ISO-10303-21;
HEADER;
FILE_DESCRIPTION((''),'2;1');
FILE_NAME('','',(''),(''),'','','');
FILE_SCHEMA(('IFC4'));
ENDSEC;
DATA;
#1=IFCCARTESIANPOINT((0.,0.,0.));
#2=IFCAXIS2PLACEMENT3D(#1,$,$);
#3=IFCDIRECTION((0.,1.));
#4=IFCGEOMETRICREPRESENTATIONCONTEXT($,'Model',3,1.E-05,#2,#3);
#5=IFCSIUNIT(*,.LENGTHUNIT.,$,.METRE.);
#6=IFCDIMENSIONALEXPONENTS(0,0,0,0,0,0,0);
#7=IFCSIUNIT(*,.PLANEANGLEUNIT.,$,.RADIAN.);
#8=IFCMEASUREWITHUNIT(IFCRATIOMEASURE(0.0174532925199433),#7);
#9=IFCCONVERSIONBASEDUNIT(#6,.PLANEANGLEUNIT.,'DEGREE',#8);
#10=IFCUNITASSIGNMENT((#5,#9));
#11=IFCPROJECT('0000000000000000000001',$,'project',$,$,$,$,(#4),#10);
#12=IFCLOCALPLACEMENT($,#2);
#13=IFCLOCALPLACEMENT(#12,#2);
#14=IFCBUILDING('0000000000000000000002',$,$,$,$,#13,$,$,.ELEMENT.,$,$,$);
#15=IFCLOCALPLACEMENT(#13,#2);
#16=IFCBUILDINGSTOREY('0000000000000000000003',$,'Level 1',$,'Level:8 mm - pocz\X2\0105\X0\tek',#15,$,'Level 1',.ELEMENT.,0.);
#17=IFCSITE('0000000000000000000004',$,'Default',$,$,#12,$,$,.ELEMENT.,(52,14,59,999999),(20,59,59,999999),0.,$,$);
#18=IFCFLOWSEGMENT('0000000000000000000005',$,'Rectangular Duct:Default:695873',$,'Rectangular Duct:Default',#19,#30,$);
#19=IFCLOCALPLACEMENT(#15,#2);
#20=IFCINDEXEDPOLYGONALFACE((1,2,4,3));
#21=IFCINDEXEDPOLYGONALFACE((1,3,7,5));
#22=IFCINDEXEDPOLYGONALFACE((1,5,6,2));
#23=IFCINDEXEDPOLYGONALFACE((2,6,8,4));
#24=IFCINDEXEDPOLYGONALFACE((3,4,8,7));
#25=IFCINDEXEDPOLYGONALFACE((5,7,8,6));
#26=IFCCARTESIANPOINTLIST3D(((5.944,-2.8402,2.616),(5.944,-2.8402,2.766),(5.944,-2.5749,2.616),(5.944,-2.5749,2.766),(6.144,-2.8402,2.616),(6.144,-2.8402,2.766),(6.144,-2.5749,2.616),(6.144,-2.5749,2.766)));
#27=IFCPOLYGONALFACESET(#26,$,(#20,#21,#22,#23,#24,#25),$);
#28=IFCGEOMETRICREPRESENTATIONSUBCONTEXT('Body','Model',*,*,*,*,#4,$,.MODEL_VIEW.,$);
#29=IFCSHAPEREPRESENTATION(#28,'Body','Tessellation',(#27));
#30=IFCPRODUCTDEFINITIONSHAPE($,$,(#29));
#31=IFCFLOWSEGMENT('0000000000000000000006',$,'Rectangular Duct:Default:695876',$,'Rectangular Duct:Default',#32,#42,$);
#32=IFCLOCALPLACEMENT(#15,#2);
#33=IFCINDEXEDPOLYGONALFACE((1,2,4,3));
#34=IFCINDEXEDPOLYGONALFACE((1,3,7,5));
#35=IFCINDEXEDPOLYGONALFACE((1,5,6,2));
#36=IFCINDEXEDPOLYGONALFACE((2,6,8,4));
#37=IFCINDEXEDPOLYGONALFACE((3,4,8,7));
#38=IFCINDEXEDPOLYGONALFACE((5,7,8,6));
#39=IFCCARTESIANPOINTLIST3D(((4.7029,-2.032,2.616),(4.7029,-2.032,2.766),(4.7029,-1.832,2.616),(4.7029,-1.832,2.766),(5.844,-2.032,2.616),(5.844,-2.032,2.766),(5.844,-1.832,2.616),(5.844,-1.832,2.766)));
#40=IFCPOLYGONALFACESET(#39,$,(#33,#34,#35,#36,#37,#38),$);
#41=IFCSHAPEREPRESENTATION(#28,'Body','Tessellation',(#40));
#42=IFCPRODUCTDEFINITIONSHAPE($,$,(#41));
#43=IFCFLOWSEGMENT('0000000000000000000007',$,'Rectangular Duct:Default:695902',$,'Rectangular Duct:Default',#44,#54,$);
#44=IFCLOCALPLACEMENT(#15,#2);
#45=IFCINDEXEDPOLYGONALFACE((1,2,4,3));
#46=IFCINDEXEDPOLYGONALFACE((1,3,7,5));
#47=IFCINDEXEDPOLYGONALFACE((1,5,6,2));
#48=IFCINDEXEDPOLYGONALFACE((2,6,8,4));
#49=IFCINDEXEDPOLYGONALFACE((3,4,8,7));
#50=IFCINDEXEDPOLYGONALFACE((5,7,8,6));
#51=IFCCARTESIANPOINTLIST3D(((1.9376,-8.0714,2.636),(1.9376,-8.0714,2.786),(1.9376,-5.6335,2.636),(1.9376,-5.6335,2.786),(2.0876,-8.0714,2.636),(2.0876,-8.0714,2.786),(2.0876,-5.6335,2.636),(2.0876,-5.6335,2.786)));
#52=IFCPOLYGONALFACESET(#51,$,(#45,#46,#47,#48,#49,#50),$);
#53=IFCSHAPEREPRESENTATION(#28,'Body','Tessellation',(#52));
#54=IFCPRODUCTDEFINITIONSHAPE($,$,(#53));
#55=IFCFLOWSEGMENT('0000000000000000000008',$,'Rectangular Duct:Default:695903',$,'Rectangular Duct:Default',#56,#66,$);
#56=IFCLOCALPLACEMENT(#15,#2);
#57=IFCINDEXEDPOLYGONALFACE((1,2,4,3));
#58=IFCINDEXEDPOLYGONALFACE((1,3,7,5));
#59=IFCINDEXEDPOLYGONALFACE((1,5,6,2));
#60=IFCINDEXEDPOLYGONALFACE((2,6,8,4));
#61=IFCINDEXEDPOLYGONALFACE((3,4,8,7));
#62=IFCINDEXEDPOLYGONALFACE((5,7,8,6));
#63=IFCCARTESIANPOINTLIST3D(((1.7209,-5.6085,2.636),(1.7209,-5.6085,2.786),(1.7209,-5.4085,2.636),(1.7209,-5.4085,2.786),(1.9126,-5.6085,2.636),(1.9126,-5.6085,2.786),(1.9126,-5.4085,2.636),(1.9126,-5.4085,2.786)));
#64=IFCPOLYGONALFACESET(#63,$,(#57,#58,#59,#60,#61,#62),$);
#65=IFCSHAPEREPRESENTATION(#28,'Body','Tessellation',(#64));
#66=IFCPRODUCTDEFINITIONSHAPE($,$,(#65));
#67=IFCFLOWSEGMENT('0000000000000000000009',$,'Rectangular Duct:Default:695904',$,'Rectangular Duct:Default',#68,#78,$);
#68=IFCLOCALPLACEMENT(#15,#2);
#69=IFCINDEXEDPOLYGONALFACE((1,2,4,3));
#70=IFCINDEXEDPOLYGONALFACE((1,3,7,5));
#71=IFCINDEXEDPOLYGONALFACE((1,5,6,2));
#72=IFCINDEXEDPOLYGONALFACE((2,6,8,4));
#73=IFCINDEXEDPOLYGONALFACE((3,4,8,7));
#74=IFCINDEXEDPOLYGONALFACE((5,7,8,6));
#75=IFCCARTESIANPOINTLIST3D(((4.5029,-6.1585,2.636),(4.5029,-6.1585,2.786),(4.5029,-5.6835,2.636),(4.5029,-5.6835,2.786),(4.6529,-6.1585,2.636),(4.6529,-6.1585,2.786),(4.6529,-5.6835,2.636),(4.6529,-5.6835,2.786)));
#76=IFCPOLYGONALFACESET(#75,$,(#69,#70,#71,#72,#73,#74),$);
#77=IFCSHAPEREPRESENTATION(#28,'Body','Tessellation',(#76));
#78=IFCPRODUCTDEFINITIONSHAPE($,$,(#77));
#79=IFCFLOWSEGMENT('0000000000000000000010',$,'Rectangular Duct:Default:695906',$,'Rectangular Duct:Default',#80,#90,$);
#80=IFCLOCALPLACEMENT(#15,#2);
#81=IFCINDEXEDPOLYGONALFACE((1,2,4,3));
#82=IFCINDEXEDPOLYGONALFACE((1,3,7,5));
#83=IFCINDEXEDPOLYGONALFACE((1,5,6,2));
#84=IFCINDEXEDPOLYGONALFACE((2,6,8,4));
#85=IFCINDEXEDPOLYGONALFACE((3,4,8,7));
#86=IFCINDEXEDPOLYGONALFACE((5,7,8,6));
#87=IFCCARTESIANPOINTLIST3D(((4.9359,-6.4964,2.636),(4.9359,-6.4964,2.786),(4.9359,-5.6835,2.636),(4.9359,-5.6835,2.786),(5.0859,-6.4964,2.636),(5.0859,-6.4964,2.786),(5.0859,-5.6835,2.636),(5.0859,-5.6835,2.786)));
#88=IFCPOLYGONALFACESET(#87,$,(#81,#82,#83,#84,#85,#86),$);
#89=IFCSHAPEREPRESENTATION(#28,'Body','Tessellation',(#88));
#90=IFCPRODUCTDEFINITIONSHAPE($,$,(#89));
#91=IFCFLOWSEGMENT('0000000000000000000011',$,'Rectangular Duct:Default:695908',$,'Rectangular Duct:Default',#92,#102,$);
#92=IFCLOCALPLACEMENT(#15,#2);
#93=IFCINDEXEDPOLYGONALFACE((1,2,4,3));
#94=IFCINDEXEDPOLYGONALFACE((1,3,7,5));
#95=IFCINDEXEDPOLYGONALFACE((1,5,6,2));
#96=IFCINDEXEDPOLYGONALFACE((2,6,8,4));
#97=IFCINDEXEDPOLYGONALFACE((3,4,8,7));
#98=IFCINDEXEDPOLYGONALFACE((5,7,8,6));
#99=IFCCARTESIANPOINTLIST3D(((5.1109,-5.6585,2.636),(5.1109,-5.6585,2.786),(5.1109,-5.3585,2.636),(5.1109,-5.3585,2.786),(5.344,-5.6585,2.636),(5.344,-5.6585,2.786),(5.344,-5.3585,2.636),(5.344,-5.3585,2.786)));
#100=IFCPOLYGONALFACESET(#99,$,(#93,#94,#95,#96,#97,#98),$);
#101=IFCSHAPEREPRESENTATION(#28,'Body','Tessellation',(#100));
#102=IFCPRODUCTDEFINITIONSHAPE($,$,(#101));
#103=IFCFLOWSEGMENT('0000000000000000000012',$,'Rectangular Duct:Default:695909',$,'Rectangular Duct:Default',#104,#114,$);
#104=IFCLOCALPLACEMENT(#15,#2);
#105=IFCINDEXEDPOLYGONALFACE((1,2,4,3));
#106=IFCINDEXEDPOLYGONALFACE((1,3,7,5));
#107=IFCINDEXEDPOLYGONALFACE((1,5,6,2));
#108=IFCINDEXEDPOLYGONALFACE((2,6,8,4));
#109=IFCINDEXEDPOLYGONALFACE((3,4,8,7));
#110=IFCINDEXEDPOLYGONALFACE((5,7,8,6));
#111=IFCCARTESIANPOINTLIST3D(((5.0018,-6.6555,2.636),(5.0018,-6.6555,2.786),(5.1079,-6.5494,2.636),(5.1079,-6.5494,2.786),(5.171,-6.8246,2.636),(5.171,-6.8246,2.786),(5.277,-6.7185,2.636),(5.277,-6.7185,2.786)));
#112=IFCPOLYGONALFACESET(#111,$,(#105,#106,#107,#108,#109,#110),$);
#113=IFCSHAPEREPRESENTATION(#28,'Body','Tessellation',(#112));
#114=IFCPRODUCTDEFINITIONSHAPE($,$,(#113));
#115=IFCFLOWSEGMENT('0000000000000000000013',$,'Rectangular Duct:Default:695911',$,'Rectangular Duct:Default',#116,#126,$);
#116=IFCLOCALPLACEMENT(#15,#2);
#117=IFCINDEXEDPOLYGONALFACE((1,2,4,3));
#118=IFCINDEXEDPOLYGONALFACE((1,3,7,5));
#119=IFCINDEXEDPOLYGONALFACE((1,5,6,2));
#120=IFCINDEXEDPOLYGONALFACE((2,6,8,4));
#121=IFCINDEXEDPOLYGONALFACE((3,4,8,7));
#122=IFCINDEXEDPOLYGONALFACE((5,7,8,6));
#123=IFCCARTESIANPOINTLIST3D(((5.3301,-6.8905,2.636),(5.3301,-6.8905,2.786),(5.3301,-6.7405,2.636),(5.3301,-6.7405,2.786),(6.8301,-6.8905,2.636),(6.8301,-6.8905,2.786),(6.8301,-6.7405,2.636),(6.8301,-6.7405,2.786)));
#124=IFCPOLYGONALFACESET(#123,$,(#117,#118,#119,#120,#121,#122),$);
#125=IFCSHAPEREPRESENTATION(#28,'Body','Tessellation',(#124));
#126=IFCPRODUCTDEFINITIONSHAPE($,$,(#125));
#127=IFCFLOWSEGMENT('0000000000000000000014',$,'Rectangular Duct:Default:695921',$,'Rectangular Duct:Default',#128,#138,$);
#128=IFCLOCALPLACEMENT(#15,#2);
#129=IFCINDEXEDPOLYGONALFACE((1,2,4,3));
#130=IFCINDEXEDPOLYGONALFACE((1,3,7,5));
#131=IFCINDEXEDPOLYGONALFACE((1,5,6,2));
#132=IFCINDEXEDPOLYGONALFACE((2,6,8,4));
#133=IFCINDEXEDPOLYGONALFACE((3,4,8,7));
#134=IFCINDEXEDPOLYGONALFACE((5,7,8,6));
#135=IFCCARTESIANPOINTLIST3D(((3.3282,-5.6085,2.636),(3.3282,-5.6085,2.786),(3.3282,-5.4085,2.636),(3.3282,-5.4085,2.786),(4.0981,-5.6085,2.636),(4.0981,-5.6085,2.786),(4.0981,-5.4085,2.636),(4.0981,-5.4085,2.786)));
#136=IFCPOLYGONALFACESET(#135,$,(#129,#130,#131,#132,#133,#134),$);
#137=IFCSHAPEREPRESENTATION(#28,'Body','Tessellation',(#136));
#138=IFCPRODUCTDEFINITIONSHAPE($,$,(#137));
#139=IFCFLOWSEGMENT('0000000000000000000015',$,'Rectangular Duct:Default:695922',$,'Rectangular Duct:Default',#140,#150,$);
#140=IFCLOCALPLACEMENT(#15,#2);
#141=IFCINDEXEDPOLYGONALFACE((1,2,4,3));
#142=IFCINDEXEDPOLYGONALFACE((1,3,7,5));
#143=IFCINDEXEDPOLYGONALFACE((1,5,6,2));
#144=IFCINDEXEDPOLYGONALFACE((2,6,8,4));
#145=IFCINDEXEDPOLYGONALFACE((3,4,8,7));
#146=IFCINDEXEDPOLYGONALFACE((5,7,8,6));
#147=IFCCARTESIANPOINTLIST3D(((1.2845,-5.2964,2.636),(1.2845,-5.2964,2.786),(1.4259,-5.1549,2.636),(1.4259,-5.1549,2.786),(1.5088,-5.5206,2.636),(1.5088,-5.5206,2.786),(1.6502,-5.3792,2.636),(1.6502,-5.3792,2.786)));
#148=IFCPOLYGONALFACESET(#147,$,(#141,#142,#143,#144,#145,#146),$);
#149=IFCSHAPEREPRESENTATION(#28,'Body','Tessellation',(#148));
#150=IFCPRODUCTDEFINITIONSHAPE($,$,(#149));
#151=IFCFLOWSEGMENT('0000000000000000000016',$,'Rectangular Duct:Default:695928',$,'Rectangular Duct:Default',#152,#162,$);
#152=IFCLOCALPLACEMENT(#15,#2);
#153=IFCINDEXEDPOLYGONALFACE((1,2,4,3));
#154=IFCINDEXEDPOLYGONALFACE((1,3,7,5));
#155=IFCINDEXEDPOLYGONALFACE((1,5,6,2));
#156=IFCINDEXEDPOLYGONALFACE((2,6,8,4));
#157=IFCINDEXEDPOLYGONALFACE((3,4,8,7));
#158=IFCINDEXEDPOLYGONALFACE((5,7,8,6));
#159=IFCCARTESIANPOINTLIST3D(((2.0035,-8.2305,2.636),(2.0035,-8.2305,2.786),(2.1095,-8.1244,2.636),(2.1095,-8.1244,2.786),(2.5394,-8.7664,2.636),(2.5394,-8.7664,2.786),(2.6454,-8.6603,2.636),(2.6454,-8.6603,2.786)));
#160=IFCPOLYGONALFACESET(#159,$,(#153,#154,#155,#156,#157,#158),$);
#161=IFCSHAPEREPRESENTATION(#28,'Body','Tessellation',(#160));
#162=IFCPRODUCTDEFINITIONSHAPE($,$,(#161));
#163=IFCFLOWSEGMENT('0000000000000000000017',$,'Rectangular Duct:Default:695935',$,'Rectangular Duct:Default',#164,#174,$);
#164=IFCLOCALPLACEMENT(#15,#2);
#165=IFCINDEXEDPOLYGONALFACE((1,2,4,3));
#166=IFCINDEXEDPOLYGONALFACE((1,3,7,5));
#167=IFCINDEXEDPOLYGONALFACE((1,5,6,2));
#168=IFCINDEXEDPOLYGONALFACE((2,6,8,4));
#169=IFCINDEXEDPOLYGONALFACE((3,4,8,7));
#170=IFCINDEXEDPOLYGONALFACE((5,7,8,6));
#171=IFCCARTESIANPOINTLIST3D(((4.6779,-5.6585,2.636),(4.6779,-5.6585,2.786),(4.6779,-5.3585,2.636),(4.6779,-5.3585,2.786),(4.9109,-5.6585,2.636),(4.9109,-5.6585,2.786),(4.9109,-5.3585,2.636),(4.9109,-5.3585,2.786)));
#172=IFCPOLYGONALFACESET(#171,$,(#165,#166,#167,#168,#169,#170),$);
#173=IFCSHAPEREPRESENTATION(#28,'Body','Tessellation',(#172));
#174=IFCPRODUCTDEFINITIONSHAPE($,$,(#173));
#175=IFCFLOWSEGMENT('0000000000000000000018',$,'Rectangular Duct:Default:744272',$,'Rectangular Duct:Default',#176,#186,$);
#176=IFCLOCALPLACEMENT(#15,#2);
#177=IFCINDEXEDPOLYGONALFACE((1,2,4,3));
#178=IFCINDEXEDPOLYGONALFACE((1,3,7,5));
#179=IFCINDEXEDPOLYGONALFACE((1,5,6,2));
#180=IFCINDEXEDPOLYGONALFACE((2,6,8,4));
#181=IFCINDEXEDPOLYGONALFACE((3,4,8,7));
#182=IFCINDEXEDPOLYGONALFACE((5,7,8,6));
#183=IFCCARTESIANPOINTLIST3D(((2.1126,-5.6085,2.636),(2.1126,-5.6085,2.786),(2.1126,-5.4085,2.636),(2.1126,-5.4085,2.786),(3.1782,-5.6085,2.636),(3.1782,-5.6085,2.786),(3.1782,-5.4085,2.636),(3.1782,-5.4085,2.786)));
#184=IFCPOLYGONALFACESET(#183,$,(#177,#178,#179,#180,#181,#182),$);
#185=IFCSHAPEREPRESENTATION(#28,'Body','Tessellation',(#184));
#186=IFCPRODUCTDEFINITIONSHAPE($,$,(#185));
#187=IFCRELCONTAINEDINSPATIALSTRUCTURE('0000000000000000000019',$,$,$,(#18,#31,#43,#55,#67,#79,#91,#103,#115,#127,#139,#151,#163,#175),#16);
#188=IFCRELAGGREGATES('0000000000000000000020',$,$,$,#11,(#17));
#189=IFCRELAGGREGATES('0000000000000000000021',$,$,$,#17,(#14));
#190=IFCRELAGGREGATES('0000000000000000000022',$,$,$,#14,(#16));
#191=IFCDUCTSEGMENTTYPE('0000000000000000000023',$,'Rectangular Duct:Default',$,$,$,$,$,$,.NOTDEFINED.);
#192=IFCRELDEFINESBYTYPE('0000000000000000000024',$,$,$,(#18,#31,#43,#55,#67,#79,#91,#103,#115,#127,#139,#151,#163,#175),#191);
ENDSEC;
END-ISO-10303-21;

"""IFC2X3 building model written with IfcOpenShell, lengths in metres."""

from ifc_helpers import new_model, entity, si_unit, converted_unit, direction, frame, frame_2d, origin, origin_2d_with_axis, place, context, subcontext, project, spatial, rectangle, extrude, type_object, element, save


model = new_model("IFC2X3")

# Units and contexts
model_context = context("Model", 3, precision=1e-05, world=origin(), true_north=direction((0.0, 1.0)))
body_context = subcontext(model_context, "Body", "Model", "MODEL_VIEW")
ifc_project = project(units=[si_unit("LENGTHUNIT", "METRE"), converted_unit("PLANEANGLEUNIT", "DEGREE", entity("IfcRatioMeasure", 0.0174532925199433), si_unit("PLANEANGLEUNIT", "RADIAN"), dimensions=[0, 0, 0, 0, 0, 0, 0])], contexts=[model_context])

# Site, building, storey
site_placement = place(None, origin())
site = spatial("IfcSite", under=ifc_project, at=site_placement, Name="Default", CompositionType="ELEMENT", RefLatitude=(52, 14, 59, 999999), RefLongitude=(20, 59, 59, 999999), RefElevation=0.0)
building_placement = place(site_placement, origin())
building = spatial("IfcBuilding", under=site, at=building_placement, CompositionType="ELEMENT")
storey_placement = place(building_placement, origin())
storey = spatial("IfcBuildingStorey", under=building, at=storey_placement, Name="Level 1", ObjectType="Level:8 mm - początek", LongName="Level 1", CompositionType="ELEMENT", Elevation=0.0)

# Flow segments
duct_segment_type_1 = type_object("IfcDuctSegmentType", Name="Rectangular Duct:Default", PredefinedType="NOTDEFINED")
flow_segment_1_placement = place(storey_placement, origin())
element("IfcFlowSegment", 1, at=flow_segment_1_placement, inside=storey, type_object=duct_segment_type_1, Name="Rectangular Duct:Default:695873", ObjectType="Rectangular Duct:Default", context=body_context, shape_type="SweptSolid", body=[
    extrude(rectangle(XDim=0.2654, YDim=0.2, at=frame_2d((0.0, 0.0), x_axis=(1.0, 0.0))), frame((6.044, -2.7075, 2.616), z_axis=(0.0, 0.0, 1.0), x_axis=(0.0, 1.0, 0.0)), (0.0, 0.0, 1.0), 0.15),
])
flow_segment_2_placement = place(storey_placement, origin())
element("IfcFlowSegment", 2, at=flow_segment_2_placement, inside=storey, type_object=duct_segment_type_1, Name="Rectangular Duct:Default:695876", ObjectType="Rectangular Duct:Default", context=body_context, shape_type="SweptSolid", body=[
    extrude(rectangle(XDim=1.1411, YDim=0.2, at=frame_2d((0.0, 0.0), x_axis=(1.0, 0.0))), frame((5.2734, -1.932, 2.616), z_axis=(0.0, 0.0, 1.0), x_axis=(-1.0, 0.0, 0.0)), (0.0, 0.0, 1.0), 0.15),
])
flow_segment_3_placement = place(storey_placement, origin())
element("IfcFlowSegment", 3, at=flow_segment_3_placement, inside=storey, type_object=duct_segment_type_1, Name="Rectangular Duct:Default:695902", ObjectType="Rectangular Duct:Default", context=body_context, shape_type="SweptSolid", body=[
    extrude(rectangle(XDim=2.4379, YDim=0.15, at=frame_2d((0.0, 0.0), x_axis=(1.0, 0.0))), frame((2.0126, -6.8524, 2.636), z_axis=(0.0, 0.0, 1.0), x_axis=(0.0, -1.0, 0.0)), (0.0, 0.0, 1.0), 0.15),
])
flow_segment_4_placement = place(storey_placement, origin())
element("IfcFlowSegment", 4, at=flow_segment_4_placement, inside=storey, type_object=duct_segment_type_1, Name="Rectangular Duct:Default:695903", ObjectType="Rectangular Duct:Default", context=body_context, shape_type="SweptSolid", body=[
    extrude(rectangle(XDim=0.1917, YDim=0.2, at=frame_2d((0.0, 0.0), x_axis=(1.0, 0.0))), frame((1.8167, -5.5085, 2.636), z_axis=(0.0, 0.0, 1.0), x_axis=(-1.0, 0.0, 0.0)), (0.0, 0.0, 1.0), 0.15),
])
flow_segment_5_placement = place(storey_placement, origin())
element("IfcFlowSegment", 5, at=flow_segment_5_placement, inside=storey, type_object=duct_segment_type_1, Name="Rectangular Duct:Default:695904", ObjectType="Rectangular Duct:Default", context=body_context, shape_type="SweptSolid", body=[
    extrude(rectangle(XDim=0.475, YDim=0.15, at=frame_2d((0.0, 0.0), x_axis=(1.0, 0.0))), frame((4.5779, -5.921, 2.636), z_axis=(0.0, 0.0, 1.0), x_axis=(0.0, 1.0, 0.0)), (0.0, 0.0, 1.0), 0.15),
])
flow_segment_6_placement = place(storey_placement, origin())
element("IfcFlowSegment", 6, at=flow_segment_6_placement, inside=storey, type_object=duct_segment_type_1, Name="Rectangular Duct:Default:695906", ObjectType="Rectangular Duct:Default", context=body_context, shape_type="SweptSolid", body=[
    extrude(rectangle(XDim=0.8129, YDim=0.15, at=origin_2d_with_axis()), frame((5.0109, -6.0899, 2.636), z_axis=(0.0, 0.0, 1.0), x_axis=(0.0, -1.0, 0.0)), (0.0, 0.0, 1.0), 0.15),
])
flow_segment_7_placement = place(storey_placement, origin())
element("IfcFlowSegment", 7, at=flow_segment_7_placement, inside=storey, type_object=duct_segment_type_1, Name="Rectangular Duct:Default:695908", ObjectType="Rectangular Duct:Default", context=body_context, shape_type="SweptSolid", body=[
    extrude(rectangle(XDim=0.2331, YDim=0.3, at=frame_2d((0.0, 0.0), x_axis=(1.0, 0.0))), frame((5.2275, -5.5085, 2.636), z_axis=(0.0, 0.0, 1.0), x_axis=(-1.0, 0.0, 0.0)), (0.0, 0.0, 1.0), 0.15),
])
flow_segment_8_placement = place(storey_placement, origin())
element("IfcFlowSegment", 8, at=flow_segment_8_placement, inside=storey, type_object=duct_segment_type_1, Name="Rectangular Duct:Default:695909", ObjectType="Rectangular Duct:Default", context=body_context, shape_type="SweptSolid", body=[
    extrude(rectangle(XDim=0.2392, YDim=0.15, at=origin_2d_with_axis()), frame((5.1394, -6.687, 2.636), z_axis=(0.0, 0.0, 1.0), x_axis=(0.707107, -0.707107, 0.0)), (0.0, 0.0, 1.0), 0.15),
])
flow_segment_9_placement = place(storey_placement, origin())
element("IfcFlowSegment", 9, at=flow_segment_9_placement, inside=storey, type_object=duct_segment_type_1, Name="Rectangular Duct:Default:695911", ObjectType="Rectangular Duct:Default", context=body_context, shape_type="SweptSolid", body=[
    extrude(rectangle(XDim=1.5, YDim=0.15, at=frame_2d((0.0, 0.0), x_axis=(1.0, 0.0))), frame((6.0801, -6.8155, 2.636)), (0.0, 0.0, 1.0), 0.15),
])
flow_segment_10_placement = place(storey_placement, origin())
element("IfcFlowSegment", 10, at=flow_segment_10_placement, inside=storey, type_object=duct_segment_type_1, Name="Rectangular Duct:Default:695921", ObjectType="Rectangular Duct:Default", context=body_context, shape_type="SweptSolid", body=[
    extrude(rectangle(XDim=0.7699, YDim=0.2, at=frame_2d((0.0, 0.0), x_axis=(1.0, 0.0))), frame((3.7131, -5.5085, 2.636)), (0.0, 0.0, 1.0), 0.15),
])
flow_segment_11_placement = place(storey_placement, origin())
element("IfcFlowSegment", 11, at=flow_segment_11_placement, inside=storey, type_object=duct_segment_type_1, Name="Rectangular Duct:Default:695922", ObjectType="Rectangular Duct:Default", context=body_context, shape_type="SweptSolid", body=[
    extrude(rectangle(XDim=0.3172, YDim=0.2, at=frame_2d((0.0, 0.0), x_axis=(1.0, 0.0))), frame((1.4674, -5.3378, 2.636), z_axis=(0.0, 0.0, 1.0), x_axis=(-0.707107, 0.707107, 0.0)), (0.0, 0.0, 1.0), 0.15),
])
flow_segment_12_placement = place(storey_placement, origin())
element("IfcFlowSegment", 12, at=flow_segment_12_placement, inside=storey, type_object=duct_segment_type_1, Name="Rectangular Duct:Default:695928", ObjectType="Rectangular Duct:Default", context=body_context, shape_type="SweptSolid", body=[
    extrude(rectangle(XDim=0.7579, YDim=0.15, at=frame_2d((0.0, 0.0), x_axis=(1.0, 0.0))), frame((2.3244, -8.4454, 2.636), z_axis=(0.0, 0.0, 1.0), x_axis=(0.707107, -0.707107, 0.0)), (0.0, 0.0, 1.0), 0.15),
])
flow_segment_13_placement = place(storey_placement, origin())
element("IfcFlowSegment", 13, at=flow_segment_13_placement, inside=storey, type_object=duct_segment_type_1, Name="Rectangular Duct:Default:695935", ObjectType="Rectangular Duct:Default", context=body_context, shape_type="SweptSolid", body=[
    extrude(rectangle(XDim=0.2331, YDim=0.3, at=frame_2d((0.0, 0.0), x_axis=(1.0, 0.0))), frame((4.7944, -5.5085, 2.636), z_axis=(0.0, 0.0, 1.0), x_axis=(-1.0, 0.0, 0.0)), (0.0, 0.0, 1.0), 0.15),
])
flow_segment_14_placement = place(storey_placement, origin())
element("IfcFlowSegment", 14, at=flow_segment_14_placement, inside=storey, type_object=duct_segment_type_1, Name="Rectangular Duct:Default:744272", ObjectType="Rectangular Duct:Default", context=body_context, shape_type="SweptSolid", body=[
    extrude(rectangle(XDim=1.0656, YDim=0.2, at=origin_2d_with_axis()), frame((2.6454, -5.5085, 2.636)), (0.0, 0.0, 1.0), 0.15),
])

save(model, "model.ifc")
